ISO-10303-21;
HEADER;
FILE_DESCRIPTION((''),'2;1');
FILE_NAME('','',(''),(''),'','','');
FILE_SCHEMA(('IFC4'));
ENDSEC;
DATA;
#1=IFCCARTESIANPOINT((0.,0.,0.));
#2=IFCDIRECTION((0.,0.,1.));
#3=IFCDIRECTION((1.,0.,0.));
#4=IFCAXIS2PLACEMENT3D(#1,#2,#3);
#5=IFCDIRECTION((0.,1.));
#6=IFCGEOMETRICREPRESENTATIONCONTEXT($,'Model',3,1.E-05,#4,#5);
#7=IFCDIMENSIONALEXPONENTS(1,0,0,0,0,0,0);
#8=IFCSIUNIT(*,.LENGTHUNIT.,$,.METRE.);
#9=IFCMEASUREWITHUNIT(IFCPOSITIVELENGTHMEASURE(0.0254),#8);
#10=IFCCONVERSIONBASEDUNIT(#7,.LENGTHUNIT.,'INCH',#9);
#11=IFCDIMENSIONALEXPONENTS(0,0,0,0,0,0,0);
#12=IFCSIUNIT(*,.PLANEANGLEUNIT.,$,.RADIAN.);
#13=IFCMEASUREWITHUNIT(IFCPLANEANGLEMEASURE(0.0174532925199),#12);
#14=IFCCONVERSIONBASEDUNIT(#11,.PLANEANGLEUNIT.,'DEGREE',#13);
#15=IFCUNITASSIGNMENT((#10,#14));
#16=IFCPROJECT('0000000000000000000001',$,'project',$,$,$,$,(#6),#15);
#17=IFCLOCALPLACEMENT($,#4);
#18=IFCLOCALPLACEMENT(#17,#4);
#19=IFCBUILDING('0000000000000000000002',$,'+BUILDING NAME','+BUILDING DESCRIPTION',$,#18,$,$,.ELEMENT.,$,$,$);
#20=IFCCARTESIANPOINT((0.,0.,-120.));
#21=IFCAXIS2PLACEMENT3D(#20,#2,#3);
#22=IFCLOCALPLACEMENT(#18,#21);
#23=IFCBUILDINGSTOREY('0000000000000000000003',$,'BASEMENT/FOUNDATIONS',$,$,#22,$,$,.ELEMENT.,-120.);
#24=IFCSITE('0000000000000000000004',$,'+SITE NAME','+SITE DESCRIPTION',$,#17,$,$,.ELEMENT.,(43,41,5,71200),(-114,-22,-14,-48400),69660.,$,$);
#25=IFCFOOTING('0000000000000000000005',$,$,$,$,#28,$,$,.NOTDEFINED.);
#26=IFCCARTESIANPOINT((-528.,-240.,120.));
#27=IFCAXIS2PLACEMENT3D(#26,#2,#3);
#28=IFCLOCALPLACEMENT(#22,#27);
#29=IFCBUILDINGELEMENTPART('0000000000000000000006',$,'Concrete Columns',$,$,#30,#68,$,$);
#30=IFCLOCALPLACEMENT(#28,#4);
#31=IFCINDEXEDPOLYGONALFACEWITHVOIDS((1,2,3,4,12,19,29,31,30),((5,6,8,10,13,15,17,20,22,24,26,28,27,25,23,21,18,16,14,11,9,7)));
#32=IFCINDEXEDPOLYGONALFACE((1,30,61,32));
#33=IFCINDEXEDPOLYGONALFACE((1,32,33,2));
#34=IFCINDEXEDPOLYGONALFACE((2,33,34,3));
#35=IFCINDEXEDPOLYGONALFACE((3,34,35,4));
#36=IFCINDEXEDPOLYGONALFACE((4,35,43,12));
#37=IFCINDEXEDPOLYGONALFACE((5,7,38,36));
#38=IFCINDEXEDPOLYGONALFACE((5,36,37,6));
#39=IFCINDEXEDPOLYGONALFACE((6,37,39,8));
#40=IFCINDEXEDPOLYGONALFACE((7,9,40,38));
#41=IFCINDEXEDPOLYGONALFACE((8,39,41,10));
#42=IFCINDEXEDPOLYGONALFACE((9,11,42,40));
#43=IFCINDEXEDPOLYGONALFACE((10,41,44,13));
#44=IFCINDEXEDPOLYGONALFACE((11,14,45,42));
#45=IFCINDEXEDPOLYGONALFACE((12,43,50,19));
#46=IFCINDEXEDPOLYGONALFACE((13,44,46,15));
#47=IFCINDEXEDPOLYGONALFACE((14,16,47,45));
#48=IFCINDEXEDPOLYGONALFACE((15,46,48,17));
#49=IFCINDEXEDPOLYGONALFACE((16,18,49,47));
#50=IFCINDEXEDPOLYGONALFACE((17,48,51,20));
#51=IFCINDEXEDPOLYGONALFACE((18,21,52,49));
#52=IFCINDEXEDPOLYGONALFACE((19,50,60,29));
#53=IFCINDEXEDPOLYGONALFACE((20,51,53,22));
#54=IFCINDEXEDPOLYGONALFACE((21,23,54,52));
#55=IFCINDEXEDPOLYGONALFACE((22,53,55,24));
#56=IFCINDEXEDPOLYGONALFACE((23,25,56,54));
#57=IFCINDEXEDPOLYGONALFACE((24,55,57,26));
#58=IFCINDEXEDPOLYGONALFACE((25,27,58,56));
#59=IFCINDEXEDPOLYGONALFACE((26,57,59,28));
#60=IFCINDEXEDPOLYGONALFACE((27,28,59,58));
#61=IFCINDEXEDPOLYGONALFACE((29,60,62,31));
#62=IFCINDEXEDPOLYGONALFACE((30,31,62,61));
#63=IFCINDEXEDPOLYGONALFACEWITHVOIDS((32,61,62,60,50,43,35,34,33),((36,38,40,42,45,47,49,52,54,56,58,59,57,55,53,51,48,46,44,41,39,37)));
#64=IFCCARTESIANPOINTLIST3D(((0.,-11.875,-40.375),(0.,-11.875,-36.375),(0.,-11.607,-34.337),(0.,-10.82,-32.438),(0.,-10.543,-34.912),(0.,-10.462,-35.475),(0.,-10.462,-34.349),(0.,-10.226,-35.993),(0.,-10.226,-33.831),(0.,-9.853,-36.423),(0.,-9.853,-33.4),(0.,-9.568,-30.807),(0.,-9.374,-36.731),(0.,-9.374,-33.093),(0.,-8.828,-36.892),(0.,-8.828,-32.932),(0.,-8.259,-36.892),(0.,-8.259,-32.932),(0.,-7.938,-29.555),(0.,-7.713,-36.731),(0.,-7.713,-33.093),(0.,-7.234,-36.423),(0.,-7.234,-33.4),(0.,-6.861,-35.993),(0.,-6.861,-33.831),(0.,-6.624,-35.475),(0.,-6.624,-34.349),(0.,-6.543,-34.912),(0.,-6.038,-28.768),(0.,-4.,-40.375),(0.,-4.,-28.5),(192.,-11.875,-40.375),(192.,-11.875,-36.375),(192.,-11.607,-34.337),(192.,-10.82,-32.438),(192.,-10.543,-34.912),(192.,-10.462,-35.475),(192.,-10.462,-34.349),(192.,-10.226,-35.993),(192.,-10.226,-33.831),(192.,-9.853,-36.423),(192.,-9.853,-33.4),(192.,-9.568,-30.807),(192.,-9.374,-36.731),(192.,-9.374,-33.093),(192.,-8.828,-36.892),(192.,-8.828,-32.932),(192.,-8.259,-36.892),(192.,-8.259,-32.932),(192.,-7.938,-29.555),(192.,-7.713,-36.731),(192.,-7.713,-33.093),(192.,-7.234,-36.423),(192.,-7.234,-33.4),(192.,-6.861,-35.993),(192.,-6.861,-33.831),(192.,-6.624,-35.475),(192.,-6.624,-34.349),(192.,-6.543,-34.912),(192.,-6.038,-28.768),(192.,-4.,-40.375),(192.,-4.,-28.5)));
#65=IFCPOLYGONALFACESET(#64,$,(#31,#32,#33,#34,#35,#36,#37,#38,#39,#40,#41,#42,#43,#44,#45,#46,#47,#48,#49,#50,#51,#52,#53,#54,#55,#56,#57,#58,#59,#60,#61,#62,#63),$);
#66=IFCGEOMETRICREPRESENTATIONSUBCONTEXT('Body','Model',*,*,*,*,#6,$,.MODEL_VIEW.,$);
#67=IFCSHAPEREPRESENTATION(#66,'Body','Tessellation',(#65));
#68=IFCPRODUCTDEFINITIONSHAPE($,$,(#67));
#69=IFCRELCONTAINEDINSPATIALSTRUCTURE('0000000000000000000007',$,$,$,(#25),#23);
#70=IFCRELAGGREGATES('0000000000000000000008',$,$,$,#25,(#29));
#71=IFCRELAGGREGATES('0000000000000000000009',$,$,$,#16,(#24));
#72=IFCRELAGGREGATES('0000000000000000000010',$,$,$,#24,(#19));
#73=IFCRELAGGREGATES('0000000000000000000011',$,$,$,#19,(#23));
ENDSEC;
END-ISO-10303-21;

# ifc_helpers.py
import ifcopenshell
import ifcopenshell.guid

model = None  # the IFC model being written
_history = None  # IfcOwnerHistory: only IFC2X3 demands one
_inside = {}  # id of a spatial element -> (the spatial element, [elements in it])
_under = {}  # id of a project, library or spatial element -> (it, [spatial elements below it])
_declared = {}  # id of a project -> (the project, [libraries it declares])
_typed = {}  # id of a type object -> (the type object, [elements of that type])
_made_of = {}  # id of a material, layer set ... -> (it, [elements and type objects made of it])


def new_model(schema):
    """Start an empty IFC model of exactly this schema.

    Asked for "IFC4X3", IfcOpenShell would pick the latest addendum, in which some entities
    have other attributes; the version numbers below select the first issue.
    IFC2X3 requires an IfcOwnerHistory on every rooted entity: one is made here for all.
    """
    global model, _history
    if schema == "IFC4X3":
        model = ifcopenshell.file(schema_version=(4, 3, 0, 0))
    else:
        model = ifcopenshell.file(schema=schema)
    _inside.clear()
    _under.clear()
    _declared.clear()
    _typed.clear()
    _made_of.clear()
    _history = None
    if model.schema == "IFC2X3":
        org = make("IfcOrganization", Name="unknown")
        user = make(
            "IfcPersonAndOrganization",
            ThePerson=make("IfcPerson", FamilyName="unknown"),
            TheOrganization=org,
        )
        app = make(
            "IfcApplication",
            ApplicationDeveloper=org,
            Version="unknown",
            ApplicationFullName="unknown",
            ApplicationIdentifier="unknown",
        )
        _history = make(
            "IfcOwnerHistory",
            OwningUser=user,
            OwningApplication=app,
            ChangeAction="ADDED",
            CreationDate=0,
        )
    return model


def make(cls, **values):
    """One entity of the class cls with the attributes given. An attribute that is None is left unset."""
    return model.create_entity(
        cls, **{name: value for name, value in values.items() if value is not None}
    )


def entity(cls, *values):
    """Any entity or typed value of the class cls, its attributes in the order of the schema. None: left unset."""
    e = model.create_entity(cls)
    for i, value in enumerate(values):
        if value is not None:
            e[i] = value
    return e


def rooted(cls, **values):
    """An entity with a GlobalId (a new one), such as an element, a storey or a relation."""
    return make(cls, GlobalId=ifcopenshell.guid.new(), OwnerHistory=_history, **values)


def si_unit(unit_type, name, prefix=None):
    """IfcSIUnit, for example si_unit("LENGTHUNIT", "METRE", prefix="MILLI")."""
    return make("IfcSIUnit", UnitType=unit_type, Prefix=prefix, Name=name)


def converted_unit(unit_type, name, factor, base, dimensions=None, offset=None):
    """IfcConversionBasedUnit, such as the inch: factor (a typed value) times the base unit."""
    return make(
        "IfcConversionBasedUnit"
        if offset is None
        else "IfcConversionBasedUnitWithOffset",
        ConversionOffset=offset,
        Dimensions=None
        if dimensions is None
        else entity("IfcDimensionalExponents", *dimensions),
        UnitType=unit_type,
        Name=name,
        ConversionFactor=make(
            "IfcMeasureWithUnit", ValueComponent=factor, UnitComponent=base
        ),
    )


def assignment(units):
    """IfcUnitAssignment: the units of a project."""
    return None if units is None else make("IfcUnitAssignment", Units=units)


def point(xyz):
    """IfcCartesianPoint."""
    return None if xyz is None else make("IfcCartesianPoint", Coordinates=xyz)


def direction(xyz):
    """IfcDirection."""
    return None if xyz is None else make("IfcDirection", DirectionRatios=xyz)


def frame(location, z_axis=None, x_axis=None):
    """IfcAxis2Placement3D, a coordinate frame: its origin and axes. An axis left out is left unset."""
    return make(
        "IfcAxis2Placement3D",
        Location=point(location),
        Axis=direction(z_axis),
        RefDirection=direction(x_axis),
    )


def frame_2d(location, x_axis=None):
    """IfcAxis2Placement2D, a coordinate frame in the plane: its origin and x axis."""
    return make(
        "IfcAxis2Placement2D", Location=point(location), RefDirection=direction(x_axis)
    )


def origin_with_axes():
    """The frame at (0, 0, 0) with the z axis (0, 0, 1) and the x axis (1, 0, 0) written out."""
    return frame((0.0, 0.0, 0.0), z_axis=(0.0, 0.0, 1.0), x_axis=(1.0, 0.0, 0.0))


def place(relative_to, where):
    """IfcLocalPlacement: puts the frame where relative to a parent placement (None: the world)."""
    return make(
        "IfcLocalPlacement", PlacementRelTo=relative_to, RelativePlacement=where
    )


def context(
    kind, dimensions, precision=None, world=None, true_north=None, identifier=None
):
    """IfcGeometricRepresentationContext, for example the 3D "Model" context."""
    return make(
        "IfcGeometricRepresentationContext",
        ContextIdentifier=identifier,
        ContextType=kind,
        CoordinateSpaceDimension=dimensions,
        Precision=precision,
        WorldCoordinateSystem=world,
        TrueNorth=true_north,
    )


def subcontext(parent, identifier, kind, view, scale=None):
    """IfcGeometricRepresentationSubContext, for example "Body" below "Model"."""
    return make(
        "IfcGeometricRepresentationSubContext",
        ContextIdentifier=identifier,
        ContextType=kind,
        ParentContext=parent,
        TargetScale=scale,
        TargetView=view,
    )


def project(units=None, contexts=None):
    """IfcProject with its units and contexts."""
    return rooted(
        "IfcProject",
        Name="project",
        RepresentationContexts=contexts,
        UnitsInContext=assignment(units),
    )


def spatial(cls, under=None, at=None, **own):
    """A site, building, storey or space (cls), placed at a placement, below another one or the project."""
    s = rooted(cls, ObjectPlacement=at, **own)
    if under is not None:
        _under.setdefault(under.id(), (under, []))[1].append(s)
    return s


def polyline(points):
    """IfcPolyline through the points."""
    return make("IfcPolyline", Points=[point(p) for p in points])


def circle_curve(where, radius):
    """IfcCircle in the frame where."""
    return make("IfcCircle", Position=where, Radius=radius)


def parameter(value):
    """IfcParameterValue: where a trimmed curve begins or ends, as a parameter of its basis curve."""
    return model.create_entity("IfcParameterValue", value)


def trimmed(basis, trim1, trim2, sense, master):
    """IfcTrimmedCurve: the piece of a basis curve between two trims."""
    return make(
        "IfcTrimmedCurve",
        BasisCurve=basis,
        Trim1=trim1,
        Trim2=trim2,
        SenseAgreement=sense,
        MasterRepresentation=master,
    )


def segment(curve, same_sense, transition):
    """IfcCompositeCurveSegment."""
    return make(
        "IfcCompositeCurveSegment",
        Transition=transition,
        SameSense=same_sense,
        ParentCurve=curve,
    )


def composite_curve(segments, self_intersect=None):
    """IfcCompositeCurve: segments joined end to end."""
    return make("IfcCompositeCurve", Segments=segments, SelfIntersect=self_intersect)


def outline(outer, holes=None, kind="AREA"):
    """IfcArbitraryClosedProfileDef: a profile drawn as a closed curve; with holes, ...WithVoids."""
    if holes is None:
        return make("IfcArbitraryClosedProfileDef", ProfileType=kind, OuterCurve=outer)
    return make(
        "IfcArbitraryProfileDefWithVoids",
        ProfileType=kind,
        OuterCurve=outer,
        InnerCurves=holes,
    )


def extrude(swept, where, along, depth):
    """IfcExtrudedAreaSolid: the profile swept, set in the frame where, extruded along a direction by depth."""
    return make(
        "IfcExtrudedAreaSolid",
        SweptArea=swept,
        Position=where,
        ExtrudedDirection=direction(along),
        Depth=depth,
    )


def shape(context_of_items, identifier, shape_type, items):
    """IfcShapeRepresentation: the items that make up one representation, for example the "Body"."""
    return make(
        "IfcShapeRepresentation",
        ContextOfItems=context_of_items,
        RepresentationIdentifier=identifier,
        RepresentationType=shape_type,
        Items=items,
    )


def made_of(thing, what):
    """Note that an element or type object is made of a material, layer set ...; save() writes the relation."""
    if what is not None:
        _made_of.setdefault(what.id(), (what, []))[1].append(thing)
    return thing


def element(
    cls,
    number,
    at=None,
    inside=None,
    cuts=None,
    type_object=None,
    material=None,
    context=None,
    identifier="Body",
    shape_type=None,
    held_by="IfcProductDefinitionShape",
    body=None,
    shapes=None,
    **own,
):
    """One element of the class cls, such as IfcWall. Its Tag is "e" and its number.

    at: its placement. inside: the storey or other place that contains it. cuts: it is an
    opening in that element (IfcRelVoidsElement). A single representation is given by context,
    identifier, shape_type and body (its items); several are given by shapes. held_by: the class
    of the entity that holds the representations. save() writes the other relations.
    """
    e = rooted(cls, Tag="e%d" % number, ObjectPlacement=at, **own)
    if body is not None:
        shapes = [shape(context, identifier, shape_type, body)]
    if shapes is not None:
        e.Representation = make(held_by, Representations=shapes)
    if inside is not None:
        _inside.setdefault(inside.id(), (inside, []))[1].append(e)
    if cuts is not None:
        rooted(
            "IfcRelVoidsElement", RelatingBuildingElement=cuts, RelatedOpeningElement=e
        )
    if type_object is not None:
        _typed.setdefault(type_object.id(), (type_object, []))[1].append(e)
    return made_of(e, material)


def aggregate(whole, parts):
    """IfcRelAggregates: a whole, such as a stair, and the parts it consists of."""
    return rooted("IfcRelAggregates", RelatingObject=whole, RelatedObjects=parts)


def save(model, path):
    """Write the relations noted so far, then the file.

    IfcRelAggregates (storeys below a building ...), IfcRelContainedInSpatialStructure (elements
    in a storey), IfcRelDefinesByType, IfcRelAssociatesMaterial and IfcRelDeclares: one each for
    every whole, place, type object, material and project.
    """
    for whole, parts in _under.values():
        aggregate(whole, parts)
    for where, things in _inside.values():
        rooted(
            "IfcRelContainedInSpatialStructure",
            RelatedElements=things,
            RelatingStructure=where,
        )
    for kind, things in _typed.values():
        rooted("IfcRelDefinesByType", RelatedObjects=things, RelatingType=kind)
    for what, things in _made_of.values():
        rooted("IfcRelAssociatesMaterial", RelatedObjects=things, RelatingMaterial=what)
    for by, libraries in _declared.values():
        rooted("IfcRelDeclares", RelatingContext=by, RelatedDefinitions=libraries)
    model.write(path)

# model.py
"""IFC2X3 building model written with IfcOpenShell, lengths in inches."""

from ifc_helpers import new_model, entity, si_unit, converted_unit, point, direction, frame, frame_2d, origin_with_axes, place, context, subcontext, project, spatial, polyline, circle_curve, parameter, trimmed, segment, composite_curve, outline, extrude, element, aggregate, save


model = new_model("IFC2X3")

# Units and contexts
model_context = context("Model", 3, precision=1e-05, world=origin_with_axes(), true_north=direction((0.0, 1.0)))
body_context = subcontext(model_context, "Body", "Model", "MODEL_VIEW")
ifc_project = project(units=[converted_unit("LENGTHUNIT", "INCH", entity("IfcPositiveLengthMeasure", 0.0254), si_unit("LENGTHUNIT", "METRE"), dimensions=[1, 0, 0, 0, 0, 0, 0]), converted_unit("PLANEANGLEUNIT", "DEGREE", entity("IfcPlaneAngleMeasure", 0.0174532925199), si_unit("PLANEANGLEUNIT", "RADIAN"), dimensions=[0, 0, 0, 0, 0, 0, 0])], contexts=[model_context])

# Site, building, storey
site_placement = place(None, origin_with_axes())
site = spatial("IfcSite", under=ifc_project, at=site_placement, Name="+SITE NAME", Description="+SITE DESCRIPTION", CompositionType="ELEMENT", RefLatitude=(43, 41, 5, 71200), RefLongitude=(-114, -22, -14, -48400), RefElevation=69660.0)
building_placement = place(site_placement, origin_with_axes())
building = spatial("IfcBuilding", under=site, at=building_placement, Name="+BUILDING NAME", Description="+BUILDING DESCRIPTION", CompositionType="ELEMENT")
storey_placement = place(building_placement, frame((0.0, 0.0, -120.0), z_axis=(0.0, 0.0, 1.0), x_axis=(1.0, 0.0, 0.0)))
storey = spatial("IfcBuildingStorey", under=building, at=storey_placement, Name="BASEMENT/FOUNDATIONS", CompositionType="ELEMENT", Elevation=-120.0)

# Footing, building element part
footing_1_placement = place(storey_placement, frame((-528.0, -240.0, 120.0), z_axis=(0.0, 0.0, 1.0), x_axis=(1.0, 0.0, 0.0)))
footing_1 = element("IfcFooting", 1, at=footing_1_placement, inside=storey, PredefinedType="NOTDEFINED")
building_element_part_1_placement = place(footing_1_placement, origin_with_axes())
building_element_part_1 = element("IfcBuildingElementPart", 2, at=building_element_part_1_placement, Name="Concrete Columns", context=body_context, shape_type="SweptSolid", body=[
    extrude(outline(composite_curve([segment(trimmed(circle_curve(frame_2d((4.0, -36.375), x_axis=(1.0, 0.0)), 7.875), [point((11.875, -36.375)), parameter(0.0)], [point((4.0, -28.5)), parameter(90.0)], True, "CARTESIAN"), True, "CONTINUOUS"), segment(polyline([(4.0, -28.5), (4.0, -40.375), (11.875, -40.375), (11.875, -36.375)]), True, "CONTINUOUS")], self_intersect=False), holes=[composite_curve([segment(trimmed(circle_curve(frame_2d((8.543, -34.912), x_axis=(-1.0, 0.0)), 2.0), [point((10.543, -34.912)), parameter(180.0)], [point((6.543, -34.912)), parameter(0.0)], False, "CARTESIAN"), True, "CONTINUOUS"), segment(trimmed(circle_curve(frame_2d((8.543, -34.912), x_axis=(1.0, 0.0)), 2.0), [point((6.543, -34.912)), parameter(180.0)], [point((10.543, -34.912)), parameter(0.0)], False, "CARTESIAN"), True, "CONTINUOUS")], self_intersect=False)]), frame((0.0, 0.0, 0.0), z_axis=(-1.0, 0.0, 0.0), x_axis=(0.0, -1.0, 0.0)), (0.0, 0.0, -1.0), 192.0),
])
aggregate(footing_1, [building_element_part_1])

save(model, "model.ifc")
